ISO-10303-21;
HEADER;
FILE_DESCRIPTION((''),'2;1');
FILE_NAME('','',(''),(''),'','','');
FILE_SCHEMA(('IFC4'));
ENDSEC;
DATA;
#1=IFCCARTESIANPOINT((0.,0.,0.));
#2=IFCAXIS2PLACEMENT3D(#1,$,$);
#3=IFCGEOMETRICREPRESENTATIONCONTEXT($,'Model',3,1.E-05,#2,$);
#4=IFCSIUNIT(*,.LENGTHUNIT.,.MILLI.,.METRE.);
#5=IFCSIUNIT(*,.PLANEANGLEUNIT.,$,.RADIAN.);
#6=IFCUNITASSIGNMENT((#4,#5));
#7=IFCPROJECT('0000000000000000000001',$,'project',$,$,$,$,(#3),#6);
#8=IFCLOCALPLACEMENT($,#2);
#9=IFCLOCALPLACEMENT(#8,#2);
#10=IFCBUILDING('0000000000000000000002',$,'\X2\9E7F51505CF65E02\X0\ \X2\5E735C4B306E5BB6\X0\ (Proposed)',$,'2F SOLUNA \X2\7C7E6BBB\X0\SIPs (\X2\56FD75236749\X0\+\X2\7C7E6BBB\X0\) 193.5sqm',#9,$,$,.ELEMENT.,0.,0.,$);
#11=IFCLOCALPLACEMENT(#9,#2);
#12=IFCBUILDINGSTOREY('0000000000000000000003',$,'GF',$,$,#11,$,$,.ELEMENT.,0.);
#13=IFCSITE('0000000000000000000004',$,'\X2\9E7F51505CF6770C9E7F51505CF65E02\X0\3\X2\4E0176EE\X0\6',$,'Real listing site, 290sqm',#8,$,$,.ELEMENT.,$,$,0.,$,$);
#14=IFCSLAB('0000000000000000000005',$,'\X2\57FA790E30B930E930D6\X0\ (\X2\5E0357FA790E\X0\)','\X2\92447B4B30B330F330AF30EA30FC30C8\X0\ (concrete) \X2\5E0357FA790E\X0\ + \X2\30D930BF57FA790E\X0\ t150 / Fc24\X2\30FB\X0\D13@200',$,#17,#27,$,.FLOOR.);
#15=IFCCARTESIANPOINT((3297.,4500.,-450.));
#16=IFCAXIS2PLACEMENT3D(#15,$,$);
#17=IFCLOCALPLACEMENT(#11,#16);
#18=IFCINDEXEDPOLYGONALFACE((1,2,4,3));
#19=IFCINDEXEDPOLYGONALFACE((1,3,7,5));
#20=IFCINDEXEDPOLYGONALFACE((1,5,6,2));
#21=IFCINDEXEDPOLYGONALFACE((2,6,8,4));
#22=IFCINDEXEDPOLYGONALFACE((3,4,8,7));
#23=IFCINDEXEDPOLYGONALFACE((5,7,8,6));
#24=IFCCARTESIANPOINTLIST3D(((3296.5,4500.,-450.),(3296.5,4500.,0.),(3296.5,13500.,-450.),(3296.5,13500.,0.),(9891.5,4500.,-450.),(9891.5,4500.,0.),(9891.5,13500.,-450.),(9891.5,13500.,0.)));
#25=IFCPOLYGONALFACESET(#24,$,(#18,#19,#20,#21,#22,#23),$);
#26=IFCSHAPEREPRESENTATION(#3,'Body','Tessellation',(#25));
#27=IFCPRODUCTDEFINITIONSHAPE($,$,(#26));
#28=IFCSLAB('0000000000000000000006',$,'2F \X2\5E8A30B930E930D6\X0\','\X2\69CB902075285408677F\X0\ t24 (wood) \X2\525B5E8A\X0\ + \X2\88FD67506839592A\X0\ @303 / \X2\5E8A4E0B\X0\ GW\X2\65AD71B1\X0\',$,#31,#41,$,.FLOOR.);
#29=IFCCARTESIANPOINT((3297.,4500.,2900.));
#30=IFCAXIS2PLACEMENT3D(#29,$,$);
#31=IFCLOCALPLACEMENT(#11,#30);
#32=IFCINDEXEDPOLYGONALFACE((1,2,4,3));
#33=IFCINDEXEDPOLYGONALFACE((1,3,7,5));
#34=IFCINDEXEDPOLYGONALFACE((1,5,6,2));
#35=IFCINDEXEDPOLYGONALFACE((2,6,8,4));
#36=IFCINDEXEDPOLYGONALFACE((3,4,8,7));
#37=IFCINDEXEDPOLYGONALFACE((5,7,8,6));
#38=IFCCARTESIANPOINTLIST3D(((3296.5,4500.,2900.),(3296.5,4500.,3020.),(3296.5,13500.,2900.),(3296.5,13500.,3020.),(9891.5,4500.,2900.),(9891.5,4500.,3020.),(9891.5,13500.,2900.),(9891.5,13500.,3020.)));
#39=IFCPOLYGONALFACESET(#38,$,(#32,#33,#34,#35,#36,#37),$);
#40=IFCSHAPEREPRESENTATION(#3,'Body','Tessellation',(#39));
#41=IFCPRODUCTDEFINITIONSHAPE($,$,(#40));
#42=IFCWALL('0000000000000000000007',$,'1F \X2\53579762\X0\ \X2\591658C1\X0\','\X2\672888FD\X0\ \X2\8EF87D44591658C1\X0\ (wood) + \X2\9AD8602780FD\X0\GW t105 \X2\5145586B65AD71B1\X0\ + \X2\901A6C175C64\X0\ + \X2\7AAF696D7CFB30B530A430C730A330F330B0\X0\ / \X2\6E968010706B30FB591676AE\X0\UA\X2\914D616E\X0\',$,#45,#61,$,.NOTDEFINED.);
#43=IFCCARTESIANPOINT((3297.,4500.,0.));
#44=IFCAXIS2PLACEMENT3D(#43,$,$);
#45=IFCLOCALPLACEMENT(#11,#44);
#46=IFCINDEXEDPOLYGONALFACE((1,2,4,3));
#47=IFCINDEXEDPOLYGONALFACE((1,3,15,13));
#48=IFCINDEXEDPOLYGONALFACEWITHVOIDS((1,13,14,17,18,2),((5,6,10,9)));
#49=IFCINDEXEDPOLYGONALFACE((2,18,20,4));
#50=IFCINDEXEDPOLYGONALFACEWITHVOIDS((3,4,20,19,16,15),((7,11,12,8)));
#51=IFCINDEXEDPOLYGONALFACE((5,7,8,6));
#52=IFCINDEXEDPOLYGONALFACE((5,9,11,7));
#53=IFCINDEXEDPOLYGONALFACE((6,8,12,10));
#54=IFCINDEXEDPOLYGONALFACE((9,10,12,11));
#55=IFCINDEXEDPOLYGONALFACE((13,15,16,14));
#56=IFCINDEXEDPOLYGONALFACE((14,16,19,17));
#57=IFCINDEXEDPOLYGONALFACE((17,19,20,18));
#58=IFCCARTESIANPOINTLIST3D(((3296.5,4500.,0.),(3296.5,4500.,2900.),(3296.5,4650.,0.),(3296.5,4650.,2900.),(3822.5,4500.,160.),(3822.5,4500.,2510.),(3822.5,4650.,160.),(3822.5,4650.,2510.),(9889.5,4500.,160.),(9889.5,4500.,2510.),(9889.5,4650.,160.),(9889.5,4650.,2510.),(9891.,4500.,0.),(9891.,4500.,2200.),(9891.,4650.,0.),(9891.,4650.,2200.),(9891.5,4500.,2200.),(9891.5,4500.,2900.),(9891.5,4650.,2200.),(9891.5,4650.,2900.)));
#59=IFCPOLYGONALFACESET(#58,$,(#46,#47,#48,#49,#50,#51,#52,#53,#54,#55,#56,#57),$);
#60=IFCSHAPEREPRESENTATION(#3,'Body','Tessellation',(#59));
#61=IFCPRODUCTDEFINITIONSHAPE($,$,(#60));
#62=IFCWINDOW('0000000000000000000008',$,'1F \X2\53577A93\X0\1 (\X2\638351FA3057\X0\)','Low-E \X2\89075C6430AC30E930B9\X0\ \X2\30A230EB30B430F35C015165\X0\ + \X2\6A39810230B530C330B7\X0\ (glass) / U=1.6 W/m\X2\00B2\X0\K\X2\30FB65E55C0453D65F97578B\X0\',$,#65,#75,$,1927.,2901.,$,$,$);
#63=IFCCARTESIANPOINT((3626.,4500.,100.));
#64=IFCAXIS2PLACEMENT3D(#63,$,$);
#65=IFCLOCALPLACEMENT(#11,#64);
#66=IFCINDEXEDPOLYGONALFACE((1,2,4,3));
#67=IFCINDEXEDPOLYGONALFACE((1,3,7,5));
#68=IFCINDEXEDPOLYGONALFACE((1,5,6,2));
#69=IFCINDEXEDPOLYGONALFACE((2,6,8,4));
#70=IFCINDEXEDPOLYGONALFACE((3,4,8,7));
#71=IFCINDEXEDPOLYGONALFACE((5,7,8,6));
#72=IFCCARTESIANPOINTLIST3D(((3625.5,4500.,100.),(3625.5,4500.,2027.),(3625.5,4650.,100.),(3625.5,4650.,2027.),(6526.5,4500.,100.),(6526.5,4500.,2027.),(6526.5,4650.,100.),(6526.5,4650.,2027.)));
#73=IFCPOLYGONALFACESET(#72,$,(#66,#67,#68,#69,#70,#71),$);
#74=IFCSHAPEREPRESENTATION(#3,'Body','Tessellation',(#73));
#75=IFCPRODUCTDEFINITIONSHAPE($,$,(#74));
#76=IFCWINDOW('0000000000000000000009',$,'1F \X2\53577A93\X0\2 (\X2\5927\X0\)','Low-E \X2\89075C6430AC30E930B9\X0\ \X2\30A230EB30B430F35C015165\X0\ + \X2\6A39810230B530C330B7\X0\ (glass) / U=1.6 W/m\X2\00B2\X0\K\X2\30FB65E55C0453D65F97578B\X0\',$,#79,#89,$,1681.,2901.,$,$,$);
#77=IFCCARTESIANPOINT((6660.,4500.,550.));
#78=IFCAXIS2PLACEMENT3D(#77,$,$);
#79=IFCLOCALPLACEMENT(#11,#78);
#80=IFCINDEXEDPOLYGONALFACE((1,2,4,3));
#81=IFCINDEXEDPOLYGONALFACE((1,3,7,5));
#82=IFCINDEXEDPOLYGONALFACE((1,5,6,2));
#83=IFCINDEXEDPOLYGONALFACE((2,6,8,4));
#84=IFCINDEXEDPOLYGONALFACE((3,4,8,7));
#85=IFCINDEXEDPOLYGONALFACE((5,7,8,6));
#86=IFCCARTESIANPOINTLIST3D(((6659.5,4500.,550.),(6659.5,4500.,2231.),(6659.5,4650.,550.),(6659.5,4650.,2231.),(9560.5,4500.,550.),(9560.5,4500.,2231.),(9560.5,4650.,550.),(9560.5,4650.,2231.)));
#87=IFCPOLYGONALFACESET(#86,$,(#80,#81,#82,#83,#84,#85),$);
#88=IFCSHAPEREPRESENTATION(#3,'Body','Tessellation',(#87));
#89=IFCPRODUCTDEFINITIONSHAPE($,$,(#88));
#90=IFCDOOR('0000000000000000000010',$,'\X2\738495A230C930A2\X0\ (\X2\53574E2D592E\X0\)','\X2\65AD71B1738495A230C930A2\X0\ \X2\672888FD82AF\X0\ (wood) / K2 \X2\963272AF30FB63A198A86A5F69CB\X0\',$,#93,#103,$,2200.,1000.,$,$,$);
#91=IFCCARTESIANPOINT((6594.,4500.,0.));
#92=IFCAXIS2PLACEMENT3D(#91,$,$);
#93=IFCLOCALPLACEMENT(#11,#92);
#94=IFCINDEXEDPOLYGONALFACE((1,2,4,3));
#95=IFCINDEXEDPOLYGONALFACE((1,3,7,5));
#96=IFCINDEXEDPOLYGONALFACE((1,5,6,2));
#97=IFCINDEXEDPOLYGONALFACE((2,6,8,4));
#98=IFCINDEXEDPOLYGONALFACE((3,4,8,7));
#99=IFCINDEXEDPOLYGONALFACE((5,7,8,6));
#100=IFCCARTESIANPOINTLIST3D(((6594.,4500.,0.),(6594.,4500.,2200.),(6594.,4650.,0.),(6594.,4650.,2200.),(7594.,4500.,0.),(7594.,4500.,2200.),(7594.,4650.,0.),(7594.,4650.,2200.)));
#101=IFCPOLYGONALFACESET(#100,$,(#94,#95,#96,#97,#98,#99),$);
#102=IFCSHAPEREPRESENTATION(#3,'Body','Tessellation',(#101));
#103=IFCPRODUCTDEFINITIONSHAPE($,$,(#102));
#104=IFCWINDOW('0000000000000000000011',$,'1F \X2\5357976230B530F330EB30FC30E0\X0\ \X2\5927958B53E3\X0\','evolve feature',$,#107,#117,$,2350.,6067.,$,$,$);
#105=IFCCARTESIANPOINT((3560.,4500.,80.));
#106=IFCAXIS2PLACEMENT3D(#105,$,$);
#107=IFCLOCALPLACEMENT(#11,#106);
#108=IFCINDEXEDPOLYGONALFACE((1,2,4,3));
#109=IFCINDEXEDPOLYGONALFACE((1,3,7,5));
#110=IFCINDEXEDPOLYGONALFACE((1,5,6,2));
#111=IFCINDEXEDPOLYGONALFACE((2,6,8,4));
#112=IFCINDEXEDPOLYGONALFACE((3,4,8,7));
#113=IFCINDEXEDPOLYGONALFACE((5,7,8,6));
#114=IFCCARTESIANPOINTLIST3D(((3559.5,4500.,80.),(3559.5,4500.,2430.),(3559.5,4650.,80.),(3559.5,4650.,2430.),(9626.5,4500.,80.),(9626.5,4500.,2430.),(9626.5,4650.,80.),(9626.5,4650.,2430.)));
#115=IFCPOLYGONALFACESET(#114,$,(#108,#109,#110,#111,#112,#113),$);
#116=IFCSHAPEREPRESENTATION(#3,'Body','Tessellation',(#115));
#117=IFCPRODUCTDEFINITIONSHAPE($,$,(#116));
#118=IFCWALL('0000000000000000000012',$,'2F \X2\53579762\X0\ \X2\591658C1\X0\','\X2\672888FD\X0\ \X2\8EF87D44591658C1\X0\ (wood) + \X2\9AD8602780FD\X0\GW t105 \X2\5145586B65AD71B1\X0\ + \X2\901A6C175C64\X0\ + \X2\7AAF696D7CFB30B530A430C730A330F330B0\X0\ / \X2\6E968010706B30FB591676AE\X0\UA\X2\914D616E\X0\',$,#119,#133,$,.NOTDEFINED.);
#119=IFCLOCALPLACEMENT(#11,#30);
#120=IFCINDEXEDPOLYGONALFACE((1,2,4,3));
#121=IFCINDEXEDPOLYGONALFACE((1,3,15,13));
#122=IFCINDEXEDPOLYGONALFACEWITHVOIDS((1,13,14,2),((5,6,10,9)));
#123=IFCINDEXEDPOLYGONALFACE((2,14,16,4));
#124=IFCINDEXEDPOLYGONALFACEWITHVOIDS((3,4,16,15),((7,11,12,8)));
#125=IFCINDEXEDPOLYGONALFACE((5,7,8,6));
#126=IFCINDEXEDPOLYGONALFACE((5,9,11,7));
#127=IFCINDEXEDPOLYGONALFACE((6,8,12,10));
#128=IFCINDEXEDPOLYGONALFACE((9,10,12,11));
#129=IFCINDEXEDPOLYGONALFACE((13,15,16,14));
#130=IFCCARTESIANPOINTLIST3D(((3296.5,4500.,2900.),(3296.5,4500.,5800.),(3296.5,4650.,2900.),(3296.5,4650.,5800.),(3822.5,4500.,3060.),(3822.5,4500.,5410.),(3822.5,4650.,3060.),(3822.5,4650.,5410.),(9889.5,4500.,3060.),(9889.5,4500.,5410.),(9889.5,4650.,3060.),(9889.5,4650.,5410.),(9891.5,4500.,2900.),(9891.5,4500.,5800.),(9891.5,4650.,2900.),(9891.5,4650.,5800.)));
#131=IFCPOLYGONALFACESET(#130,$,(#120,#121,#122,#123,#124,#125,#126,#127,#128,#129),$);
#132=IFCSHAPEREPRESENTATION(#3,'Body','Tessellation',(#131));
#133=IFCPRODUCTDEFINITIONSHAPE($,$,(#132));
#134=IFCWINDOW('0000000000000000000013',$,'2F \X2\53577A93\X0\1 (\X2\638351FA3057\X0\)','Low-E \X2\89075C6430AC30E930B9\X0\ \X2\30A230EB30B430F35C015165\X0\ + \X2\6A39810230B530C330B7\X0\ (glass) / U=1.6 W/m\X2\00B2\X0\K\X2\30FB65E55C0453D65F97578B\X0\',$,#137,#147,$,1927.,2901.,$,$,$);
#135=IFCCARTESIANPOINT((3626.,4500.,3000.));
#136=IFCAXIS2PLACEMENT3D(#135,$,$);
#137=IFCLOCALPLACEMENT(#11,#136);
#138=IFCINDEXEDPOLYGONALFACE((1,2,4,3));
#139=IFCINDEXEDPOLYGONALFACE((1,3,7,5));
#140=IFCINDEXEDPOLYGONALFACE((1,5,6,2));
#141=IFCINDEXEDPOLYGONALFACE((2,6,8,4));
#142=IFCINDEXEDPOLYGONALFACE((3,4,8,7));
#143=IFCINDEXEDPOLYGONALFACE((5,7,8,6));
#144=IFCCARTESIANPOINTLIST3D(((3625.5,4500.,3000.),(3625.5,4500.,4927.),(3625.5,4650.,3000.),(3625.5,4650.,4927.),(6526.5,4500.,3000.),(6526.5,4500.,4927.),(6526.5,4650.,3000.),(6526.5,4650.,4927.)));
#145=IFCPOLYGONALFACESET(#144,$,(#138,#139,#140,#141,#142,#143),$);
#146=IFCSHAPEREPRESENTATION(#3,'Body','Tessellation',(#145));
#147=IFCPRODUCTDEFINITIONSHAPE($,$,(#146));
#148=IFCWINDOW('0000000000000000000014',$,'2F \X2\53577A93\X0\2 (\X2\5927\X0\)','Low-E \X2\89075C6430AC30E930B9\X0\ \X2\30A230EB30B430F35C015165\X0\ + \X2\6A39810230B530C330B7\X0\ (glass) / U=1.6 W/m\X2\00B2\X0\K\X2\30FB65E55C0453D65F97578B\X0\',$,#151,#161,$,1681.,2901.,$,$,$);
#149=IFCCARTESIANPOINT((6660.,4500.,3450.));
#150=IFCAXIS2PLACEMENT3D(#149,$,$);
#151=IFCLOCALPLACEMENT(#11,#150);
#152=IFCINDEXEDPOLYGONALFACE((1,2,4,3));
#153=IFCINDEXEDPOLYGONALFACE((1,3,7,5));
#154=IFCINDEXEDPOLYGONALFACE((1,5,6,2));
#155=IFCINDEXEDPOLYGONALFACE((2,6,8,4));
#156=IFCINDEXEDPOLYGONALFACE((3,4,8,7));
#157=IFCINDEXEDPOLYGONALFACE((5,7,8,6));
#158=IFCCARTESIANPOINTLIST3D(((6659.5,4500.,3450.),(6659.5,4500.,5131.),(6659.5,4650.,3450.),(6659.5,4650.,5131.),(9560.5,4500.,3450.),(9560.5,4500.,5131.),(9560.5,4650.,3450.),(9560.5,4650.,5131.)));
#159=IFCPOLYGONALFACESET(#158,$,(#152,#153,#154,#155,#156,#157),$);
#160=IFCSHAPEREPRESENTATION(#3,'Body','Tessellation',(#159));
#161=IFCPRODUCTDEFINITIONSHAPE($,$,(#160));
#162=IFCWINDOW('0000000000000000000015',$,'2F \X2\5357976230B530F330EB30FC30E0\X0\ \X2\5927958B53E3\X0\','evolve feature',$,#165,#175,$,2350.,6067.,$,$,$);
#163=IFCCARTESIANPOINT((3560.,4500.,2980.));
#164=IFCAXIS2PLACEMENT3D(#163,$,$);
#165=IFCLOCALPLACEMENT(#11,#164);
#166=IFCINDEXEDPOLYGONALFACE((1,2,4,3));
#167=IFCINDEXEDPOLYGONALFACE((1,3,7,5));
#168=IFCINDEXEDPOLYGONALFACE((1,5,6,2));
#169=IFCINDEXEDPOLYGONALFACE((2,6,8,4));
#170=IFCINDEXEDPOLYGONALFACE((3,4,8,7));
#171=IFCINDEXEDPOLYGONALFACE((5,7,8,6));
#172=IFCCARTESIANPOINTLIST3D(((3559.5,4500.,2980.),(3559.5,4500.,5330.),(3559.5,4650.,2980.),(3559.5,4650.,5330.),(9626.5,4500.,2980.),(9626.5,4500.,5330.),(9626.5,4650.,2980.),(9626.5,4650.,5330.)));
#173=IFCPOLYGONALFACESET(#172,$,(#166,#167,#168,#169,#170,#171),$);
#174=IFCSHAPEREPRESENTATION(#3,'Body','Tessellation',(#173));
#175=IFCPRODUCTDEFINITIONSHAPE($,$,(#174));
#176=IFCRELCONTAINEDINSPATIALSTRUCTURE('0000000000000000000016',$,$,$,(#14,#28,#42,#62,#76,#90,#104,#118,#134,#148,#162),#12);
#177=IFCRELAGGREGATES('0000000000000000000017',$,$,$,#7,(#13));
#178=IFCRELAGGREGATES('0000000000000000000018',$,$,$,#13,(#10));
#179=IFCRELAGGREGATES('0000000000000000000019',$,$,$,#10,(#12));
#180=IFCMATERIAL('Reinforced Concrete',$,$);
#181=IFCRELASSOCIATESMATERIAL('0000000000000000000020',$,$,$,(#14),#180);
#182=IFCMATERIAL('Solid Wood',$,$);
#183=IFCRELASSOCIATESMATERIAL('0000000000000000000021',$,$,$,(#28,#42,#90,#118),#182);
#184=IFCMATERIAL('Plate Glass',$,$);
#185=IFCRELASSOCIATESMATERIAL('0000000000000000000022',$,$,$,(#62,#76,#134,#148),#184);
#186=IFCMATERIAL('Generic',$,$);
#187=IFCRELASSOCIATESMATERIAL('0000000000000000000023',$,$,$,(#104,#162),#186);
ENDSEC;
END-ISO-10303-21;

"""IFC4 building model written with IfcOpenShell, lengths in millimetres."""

from ifc_helpers import new_model, si_unit, frame, frame_2d, origin, place, context, project, spatial, rectangle, extrude, material, element, fill, save


model = new_model("IFC4")

# Units and contexts
model_context = context("Model", 3, precision=1e-05, world=origin())
ifc_project = project(units=[si_unit("LENGTHUNIT", "METRE", prefix="MILLI"), si_unit("PLANEANGLEUNIT", "RADIAN")], contexts=[model_context])

# Site, building, storey
site_placement = place(None, origin())
site = spatial("IfcSite", under=ifc_project, at=site_placement, Name="鹿児島県鹿児島市3丁目6", ObjectType="Real listing site, 290sqm", CompositionType="ELEMENT", RefElevation=0.0)
building_placement = place(site_placement, origin())
building = spatial("IfcBuilding", under=site, at=building_placement, Name="鹿児島市 平屋の家 (Proposed)", ObjectType="2F SOLUNA 籾殻SIPs (国産杉+籾殻) 193.5sqm", CompositionType="ELEMENT", ElevationOfRefHeight=0.0, ElevationOfTerrain=0.0)
storey_placement = place(building_placement, origin())
storey = spatial("IfcBuildingStorey", under=building, at=storey_placement, Name="GF", CompositionType="ELEMENT", Elevation=0.0)

# Slabs
ifc_material_1 = material(Name="Reinforced Concrete")
slab_1_placement = place(storey_placement, frame((3297.0, 4500.0, -450.0)))
element("IfcSlab", 1, at=slab_1_placement, inside=storey, material=ifc_material_1, Name="基礎スラブ (布基礎)", Description="鉄筋コンクリート (concrete) 布基礎 + ベタ基礎 t150 / Fc24・D13@200", PredefinedType="FLOOR", context=model_context, shape_type="SweptSolid", body=[
    extrude(rectangle(XDim=6595.0, YDim=9000.0, at=frame_2d((3297.0, 4500.0))), frame((3297.0, 4500.0, -450.0)), (0.0, 0.0, 1.0), 450.0),
])
ifc_material_2 = material(Name="Solid Wood")
slab_2_placement = place(storey_placement, frame((3297.0, 4500.0, 2900.0)))
element("IfcSlab", 2, at=slab_2_placement, inside=storey, material=ifc_material_2, Name="2F 床スラブ", Description="構造用合板 t24 (wood) 剛床 + 製材根太 @303 / 床下 GW断熱", PredefinedType="FLOOR", context=model_context, shape_type="SweptSolid", body=[
    extrude(rectangle(XDim=6595.0, YDim=9000.0, at=frame_2d((3297.0, 4500.0))), frame((3297.0, 4500.0, 2900.0)), (0.0, 0.0, 1.0), 120.0),
])

# Wall, openings, windows, door
wall_1_placement = place(storey_placement, frame((3297.0, 4500.0, 0.0)))
wall_1 = element("IfcWall", 3, at=wall_1_placement, inside=storey, material=ifc_material_2, Name="1F 南面 外壁", Description="木製 軸組外壁 (wood) + 高性能GW t105 充填断熱 + 通気層 + 窯業系サイディング / 準耐火・外皮UA配慮", PredefinedType="NOTDEFINED", context=model_context, shape_type="SweptSolid", body=[
    extrude(rectangle(XDim=6595.0, YDim=150.0, at=frame_2d((3297.0, 75.0))), frame((3297.0, 4500.0, 0.0)), (0.0, 0.0, 1.0), 2900.0),
])
opening_1_placement = place(storey_placement, frame((3626.0, 4500.0, 100.0)))
opening_1 = element("IfcOpeningElement", 4, at=opening_1_placement, cuts=wall_1, PredefinedType="NOTDEFINED", context=model_context, shape_type="SweptSolid", body=[
    extrude(rectangle(XDim=2901.0, YDim=150.0, at=frame_2d((1450.0, 75.0))), frame((3626.0, 4500.0, 100.0)), (0.0, 0.0, 1.0), 1927.0),
])
opening_2_placement = place(storey_placement, frame((6660.0, 4500.0, 550.0)))
opening_2 = element("IfcOpeningElement", 5, at=opening_2_placement, cuts=wall_1, PredefinedType="NOTDEFINED", context=model_context, shape_type="SweptSolid", body=[
    extrude(rectangle(XDim=2901.0, YDim=150.0, at=frame_2d((1450.0, 75.0))), frame((6660.0, 4500.0, 550.0)), (0.0, 0.0, 1.0), 1681.0),
])
opening_3_placement = place(storey_placement, frame((6594.0, 4500.0, 0.0)))
opening_3 = element("IfcOpeningElement", 6, at=opening_3_placement, cuts=wall_1, PredefinedType="NOTDEFINED", context=model_context, shape_type="SweptSolid", body=[
    extrude(rectangle(XDim=1000.0, YDim=150.0, at=frame_2d((500.0, 75.0))), frame((6594.0, 4500.0, 0.0)), (0.0, 0.0, 1.0), 2200.0),
])
opening_4_placement = place(storey_placement, frame((3560.0, 4500.0, 80.0)))
opening_4 = element("IfcOpeningElement", 7, at=opening_4_placement, cuts=wall_1, PredefinedType="NOTDEFINED", context=model_context, shape_type="SweptSolid", body=[
    extrude(rectangle(XDim=6067.0, YDim=150.0, at=frame_2d((3033.0, 75.0))), frame((3560.0, 4500.0, 80.0)), (0.0, 0.0, 1.0), 2350.0),
])
ifc_material_3 = material(Name="Plate Glass")
window_1_placement = place(storey_placement, frame((3626.0, 4500.0, 100.0)))
window_1 = element("IfcWindow", 8, at=window_1_placement, inside=storey, material=ifc_material_3, Name="1F 南窓1 (掃出し)", Description="Low-E 複層ガラス アルゴン封入 + 樹脂サッシ (glass) / U=1.6 W/m²K・日射取得型", OverallHeight=1927.0, OverallWidth=2901.0, context=model_context, shape_type="SweptSolid", body=[
    extrude(rectangle(XDim=2901.0, YDim=150.0, at=frame_2d((1450.0, 75.0))), frame((3626.0, 4500.0, 100.0)), (0.0, 0.0, 1.0), 1927.0),
])
fill(opening_1, window_1)
window_2_placement = place(storey_placement, frame((6660.0, 4500.0, 550.0)))
window_2 = element("IfcWindow", 9, at=window_2_placement, inside=storey, material=ifc_material_3, Name="1F 南窓2 (大)", Description="Low-E 複層ガラス アルゴン封入 + 樹脂サッシ (glass) / U=1.6 W/m²K・日射取得型", OverallHeight=1681.0, OverallWidth=2901.0, context=model_context, shape_type="SweptSolid", body=[
    extrude(rectangle(XDim=2901.0, YDim=150.0, at=frame_2d((1450.0, 75.0))), frame((6660.0, 4500.0, 550.0)), (0.0, 0.0, 1.0), 1681.0),
])
fill(opening_2, window_2)
door_placement = place(storey_placement, frame((6594.0, 4500.0, 0.0)))
door = element("IfcDoor", 10, at=door_placement, inside=storey, material=ifc_material_2, Name="玄関ドア (南中央)", Description="断熱玄関ドア 木製芯 (wood) / K2 防犯・採風機構", OverallHeight=2200.0, OverallWidth=1000.0, context=model_context, shape_type="SweptSolid", body=[
    extrude(rectangle(XDim=1000.0, YDim=150.0, at=frame_2d((500.0, 75.0))), frame((6594.0, 4500.0, 0.0)), (0.0, 0.0, 1.0), 2200.0),
])
fill(opening_3, door)
ifc_material_4 = material(Name="Generic")
window_3_placement = place(storey_placement, frame((3560.0, 4500.0, 80.0)))
window_3 = element("IfcWindow", 11, at=window_3_placement, inside=storey, material=ifc_material_4, Name="1F 南面サンルーム 大開口", Description="evolve feature", OverallHeight=2350.0, OverallWidth=6067.0, context=model_context, shape_type="SweptSolid", body=[
    extrude(rectangle(XDim=6067.0, YDim=150.0, at=frame_2d((3033.0, 75.0))), frame((3560.0, 4500.0, 80.0)), (0.0, 0.0, 1.0), 2350.0),
])
fill(opening_4, window_3)

# Wall, openings, windows
wall_2_placement = place(storey_placement, frame((3297.0, 4500.0, 2900.0)))
wall_2 = element("IfcWall", 12, at=wall_2_placement, inside=storey, material=ifc_material_2, Name="2F 南面 外壁", Description="木製 軸組外壁 (wood) + 高性能GW t105 充填断熱 + 通気層 + 窯業系サイディング / 準耐火・外皮UA配慮", PredefinedType="NOTDEFINED", context=model_context, shape_type="SweptSolid", body=[
    extrude(rectangle(XDim=6595.0, YDim=150.0, at=frame_2d((3297.0, 75.0))), frame((3297.0, 4500.0, 2900.0)), (0.0, 0.0, 1.0), 2900.0),
])
opening_5_placement = place(storey_placement, frame((3626.0, 4500.0, 3000.0)))
opening_5 = element("IfcOpeningElement", 13, at=opening_5_placement, cuts=wall_2, PredefinedType="NOTDEFINED", context=model_context, shape_type="SweptSolid", body=[
    extrude(rectangle(XDim=2901.0, YDim=150.0, at=frame_2d((1450.0, 75.0))), frame((3626.0, 4500.0, 3000.0)), (0.0, 0.0, 1.0), 1927.0),
])
opening_6_placement = place(storey_placement, frame((6660.0, 4500.0, 3450.0)))
opening_6 = element("IfcOpeningElement", 14, at=opening_6_placement, cuts=wall_2, PredefinedType="NOTDEFINED", context=model_context, shape_type="SweptSolid", body=[
    extrude(rectangle(XDim=2901.0, YDim=150.0, at=frame_2d((1450.0, 75.0))), frame((6660.0, 4500.0, 3450.0)), (0.0, 0.0, 1.0), 1681.0),
])
opening_7_placement = place(storey_placement, frame((3560.0, 4500.0, 2980.0)))
opening_7 = element("IfcOpeningElement", 15, at=opening_7_placement, cuts=wall_2, PredefinedType="NOTDEFINED", context=model_context, shape_type="SweptSolid", body=[
    extrude(rectangle(XDim=6067.0, YDim=150.0, at=frame_2d((3033.0, 75.0))), frame((3560.0, 4500.0, 2980.0)), (0.0, 0.0, 1.0), 2350.0),
])
window_4_placement = place(storey_placement, frame((3626.0, 4500.0, 3000.0)))
window_4 = element("IfcWindow", 16, at=window_4_placement, inside=storey, material=ifc_material_3, Name="2F 南窓1 (掃出し)", Description="Low-E 複層ガラス アルゴン封入 + 樹脂サッシ (glass) / U=1.6 W/m²K・日射取得型", OverallHeight=1927.0, OverallWidth=2901.0, context=model_context, shape_type="SweptSolid", body=[
    extrude(rectangle(XDim=2901.0, YDim=150.0, at=frame_2d((1450.0, 75.0))), frame((3626.0, 4500.0, 3000.0)), (0.0, 0.0, 1.0), 1927.0),
])
fill(opening_5, window_4)
window_5_placement = place(storey_placement, frame((6660.0, 4500.0, 3450.0)))
window_5 = element("IfcWindow", 17, at=window_5_placement, inside=storey, material=ifc_material_3, Name="2F 南窓2 (大)", Description="Low-E 複層ガラス アルゴン封入 + 樹脂サッシ (glass) / U=1.6 W/m²K・日射取得型", OverallHeight=1681.0, OverallWidth=2901.0, context=model_context, shape_type="SweptSolid", body=[
    extrude(rectangle(XDim=2901.0, YDim=150.0, at=frame_2d((1450.0, 75.0))), frame((6660.0, 4500.0, 3450.0)), (0.0, 0.0, 1.0), 1681.0),
])
fill(opening_6, window_5)
window_6_placement = place(storey_placement, frame((3560.0, 4500.0, 2980.0)))
window_6 = element("IfcWindow", 18, at=window_6_placement, inside=storey, material=ifc_material_4, Name="2F 南面サンルーム 大開口", Description="evolve feature", OverallHeight=2350.0, OverallWidth=6067.0, context=model_context, shape_type="SweptSolid", body=[
    extrude(rectangle(XDim=6067.0, YDim=150.0, at=frame_2d((3033.0, 75.0))), frame((3560.0, 4500.0, 2980.0)), (0.0, 0.0, 1.0), 2350.0),
])
fill(opening_7, window_6)

save(model, "model.ifc")
